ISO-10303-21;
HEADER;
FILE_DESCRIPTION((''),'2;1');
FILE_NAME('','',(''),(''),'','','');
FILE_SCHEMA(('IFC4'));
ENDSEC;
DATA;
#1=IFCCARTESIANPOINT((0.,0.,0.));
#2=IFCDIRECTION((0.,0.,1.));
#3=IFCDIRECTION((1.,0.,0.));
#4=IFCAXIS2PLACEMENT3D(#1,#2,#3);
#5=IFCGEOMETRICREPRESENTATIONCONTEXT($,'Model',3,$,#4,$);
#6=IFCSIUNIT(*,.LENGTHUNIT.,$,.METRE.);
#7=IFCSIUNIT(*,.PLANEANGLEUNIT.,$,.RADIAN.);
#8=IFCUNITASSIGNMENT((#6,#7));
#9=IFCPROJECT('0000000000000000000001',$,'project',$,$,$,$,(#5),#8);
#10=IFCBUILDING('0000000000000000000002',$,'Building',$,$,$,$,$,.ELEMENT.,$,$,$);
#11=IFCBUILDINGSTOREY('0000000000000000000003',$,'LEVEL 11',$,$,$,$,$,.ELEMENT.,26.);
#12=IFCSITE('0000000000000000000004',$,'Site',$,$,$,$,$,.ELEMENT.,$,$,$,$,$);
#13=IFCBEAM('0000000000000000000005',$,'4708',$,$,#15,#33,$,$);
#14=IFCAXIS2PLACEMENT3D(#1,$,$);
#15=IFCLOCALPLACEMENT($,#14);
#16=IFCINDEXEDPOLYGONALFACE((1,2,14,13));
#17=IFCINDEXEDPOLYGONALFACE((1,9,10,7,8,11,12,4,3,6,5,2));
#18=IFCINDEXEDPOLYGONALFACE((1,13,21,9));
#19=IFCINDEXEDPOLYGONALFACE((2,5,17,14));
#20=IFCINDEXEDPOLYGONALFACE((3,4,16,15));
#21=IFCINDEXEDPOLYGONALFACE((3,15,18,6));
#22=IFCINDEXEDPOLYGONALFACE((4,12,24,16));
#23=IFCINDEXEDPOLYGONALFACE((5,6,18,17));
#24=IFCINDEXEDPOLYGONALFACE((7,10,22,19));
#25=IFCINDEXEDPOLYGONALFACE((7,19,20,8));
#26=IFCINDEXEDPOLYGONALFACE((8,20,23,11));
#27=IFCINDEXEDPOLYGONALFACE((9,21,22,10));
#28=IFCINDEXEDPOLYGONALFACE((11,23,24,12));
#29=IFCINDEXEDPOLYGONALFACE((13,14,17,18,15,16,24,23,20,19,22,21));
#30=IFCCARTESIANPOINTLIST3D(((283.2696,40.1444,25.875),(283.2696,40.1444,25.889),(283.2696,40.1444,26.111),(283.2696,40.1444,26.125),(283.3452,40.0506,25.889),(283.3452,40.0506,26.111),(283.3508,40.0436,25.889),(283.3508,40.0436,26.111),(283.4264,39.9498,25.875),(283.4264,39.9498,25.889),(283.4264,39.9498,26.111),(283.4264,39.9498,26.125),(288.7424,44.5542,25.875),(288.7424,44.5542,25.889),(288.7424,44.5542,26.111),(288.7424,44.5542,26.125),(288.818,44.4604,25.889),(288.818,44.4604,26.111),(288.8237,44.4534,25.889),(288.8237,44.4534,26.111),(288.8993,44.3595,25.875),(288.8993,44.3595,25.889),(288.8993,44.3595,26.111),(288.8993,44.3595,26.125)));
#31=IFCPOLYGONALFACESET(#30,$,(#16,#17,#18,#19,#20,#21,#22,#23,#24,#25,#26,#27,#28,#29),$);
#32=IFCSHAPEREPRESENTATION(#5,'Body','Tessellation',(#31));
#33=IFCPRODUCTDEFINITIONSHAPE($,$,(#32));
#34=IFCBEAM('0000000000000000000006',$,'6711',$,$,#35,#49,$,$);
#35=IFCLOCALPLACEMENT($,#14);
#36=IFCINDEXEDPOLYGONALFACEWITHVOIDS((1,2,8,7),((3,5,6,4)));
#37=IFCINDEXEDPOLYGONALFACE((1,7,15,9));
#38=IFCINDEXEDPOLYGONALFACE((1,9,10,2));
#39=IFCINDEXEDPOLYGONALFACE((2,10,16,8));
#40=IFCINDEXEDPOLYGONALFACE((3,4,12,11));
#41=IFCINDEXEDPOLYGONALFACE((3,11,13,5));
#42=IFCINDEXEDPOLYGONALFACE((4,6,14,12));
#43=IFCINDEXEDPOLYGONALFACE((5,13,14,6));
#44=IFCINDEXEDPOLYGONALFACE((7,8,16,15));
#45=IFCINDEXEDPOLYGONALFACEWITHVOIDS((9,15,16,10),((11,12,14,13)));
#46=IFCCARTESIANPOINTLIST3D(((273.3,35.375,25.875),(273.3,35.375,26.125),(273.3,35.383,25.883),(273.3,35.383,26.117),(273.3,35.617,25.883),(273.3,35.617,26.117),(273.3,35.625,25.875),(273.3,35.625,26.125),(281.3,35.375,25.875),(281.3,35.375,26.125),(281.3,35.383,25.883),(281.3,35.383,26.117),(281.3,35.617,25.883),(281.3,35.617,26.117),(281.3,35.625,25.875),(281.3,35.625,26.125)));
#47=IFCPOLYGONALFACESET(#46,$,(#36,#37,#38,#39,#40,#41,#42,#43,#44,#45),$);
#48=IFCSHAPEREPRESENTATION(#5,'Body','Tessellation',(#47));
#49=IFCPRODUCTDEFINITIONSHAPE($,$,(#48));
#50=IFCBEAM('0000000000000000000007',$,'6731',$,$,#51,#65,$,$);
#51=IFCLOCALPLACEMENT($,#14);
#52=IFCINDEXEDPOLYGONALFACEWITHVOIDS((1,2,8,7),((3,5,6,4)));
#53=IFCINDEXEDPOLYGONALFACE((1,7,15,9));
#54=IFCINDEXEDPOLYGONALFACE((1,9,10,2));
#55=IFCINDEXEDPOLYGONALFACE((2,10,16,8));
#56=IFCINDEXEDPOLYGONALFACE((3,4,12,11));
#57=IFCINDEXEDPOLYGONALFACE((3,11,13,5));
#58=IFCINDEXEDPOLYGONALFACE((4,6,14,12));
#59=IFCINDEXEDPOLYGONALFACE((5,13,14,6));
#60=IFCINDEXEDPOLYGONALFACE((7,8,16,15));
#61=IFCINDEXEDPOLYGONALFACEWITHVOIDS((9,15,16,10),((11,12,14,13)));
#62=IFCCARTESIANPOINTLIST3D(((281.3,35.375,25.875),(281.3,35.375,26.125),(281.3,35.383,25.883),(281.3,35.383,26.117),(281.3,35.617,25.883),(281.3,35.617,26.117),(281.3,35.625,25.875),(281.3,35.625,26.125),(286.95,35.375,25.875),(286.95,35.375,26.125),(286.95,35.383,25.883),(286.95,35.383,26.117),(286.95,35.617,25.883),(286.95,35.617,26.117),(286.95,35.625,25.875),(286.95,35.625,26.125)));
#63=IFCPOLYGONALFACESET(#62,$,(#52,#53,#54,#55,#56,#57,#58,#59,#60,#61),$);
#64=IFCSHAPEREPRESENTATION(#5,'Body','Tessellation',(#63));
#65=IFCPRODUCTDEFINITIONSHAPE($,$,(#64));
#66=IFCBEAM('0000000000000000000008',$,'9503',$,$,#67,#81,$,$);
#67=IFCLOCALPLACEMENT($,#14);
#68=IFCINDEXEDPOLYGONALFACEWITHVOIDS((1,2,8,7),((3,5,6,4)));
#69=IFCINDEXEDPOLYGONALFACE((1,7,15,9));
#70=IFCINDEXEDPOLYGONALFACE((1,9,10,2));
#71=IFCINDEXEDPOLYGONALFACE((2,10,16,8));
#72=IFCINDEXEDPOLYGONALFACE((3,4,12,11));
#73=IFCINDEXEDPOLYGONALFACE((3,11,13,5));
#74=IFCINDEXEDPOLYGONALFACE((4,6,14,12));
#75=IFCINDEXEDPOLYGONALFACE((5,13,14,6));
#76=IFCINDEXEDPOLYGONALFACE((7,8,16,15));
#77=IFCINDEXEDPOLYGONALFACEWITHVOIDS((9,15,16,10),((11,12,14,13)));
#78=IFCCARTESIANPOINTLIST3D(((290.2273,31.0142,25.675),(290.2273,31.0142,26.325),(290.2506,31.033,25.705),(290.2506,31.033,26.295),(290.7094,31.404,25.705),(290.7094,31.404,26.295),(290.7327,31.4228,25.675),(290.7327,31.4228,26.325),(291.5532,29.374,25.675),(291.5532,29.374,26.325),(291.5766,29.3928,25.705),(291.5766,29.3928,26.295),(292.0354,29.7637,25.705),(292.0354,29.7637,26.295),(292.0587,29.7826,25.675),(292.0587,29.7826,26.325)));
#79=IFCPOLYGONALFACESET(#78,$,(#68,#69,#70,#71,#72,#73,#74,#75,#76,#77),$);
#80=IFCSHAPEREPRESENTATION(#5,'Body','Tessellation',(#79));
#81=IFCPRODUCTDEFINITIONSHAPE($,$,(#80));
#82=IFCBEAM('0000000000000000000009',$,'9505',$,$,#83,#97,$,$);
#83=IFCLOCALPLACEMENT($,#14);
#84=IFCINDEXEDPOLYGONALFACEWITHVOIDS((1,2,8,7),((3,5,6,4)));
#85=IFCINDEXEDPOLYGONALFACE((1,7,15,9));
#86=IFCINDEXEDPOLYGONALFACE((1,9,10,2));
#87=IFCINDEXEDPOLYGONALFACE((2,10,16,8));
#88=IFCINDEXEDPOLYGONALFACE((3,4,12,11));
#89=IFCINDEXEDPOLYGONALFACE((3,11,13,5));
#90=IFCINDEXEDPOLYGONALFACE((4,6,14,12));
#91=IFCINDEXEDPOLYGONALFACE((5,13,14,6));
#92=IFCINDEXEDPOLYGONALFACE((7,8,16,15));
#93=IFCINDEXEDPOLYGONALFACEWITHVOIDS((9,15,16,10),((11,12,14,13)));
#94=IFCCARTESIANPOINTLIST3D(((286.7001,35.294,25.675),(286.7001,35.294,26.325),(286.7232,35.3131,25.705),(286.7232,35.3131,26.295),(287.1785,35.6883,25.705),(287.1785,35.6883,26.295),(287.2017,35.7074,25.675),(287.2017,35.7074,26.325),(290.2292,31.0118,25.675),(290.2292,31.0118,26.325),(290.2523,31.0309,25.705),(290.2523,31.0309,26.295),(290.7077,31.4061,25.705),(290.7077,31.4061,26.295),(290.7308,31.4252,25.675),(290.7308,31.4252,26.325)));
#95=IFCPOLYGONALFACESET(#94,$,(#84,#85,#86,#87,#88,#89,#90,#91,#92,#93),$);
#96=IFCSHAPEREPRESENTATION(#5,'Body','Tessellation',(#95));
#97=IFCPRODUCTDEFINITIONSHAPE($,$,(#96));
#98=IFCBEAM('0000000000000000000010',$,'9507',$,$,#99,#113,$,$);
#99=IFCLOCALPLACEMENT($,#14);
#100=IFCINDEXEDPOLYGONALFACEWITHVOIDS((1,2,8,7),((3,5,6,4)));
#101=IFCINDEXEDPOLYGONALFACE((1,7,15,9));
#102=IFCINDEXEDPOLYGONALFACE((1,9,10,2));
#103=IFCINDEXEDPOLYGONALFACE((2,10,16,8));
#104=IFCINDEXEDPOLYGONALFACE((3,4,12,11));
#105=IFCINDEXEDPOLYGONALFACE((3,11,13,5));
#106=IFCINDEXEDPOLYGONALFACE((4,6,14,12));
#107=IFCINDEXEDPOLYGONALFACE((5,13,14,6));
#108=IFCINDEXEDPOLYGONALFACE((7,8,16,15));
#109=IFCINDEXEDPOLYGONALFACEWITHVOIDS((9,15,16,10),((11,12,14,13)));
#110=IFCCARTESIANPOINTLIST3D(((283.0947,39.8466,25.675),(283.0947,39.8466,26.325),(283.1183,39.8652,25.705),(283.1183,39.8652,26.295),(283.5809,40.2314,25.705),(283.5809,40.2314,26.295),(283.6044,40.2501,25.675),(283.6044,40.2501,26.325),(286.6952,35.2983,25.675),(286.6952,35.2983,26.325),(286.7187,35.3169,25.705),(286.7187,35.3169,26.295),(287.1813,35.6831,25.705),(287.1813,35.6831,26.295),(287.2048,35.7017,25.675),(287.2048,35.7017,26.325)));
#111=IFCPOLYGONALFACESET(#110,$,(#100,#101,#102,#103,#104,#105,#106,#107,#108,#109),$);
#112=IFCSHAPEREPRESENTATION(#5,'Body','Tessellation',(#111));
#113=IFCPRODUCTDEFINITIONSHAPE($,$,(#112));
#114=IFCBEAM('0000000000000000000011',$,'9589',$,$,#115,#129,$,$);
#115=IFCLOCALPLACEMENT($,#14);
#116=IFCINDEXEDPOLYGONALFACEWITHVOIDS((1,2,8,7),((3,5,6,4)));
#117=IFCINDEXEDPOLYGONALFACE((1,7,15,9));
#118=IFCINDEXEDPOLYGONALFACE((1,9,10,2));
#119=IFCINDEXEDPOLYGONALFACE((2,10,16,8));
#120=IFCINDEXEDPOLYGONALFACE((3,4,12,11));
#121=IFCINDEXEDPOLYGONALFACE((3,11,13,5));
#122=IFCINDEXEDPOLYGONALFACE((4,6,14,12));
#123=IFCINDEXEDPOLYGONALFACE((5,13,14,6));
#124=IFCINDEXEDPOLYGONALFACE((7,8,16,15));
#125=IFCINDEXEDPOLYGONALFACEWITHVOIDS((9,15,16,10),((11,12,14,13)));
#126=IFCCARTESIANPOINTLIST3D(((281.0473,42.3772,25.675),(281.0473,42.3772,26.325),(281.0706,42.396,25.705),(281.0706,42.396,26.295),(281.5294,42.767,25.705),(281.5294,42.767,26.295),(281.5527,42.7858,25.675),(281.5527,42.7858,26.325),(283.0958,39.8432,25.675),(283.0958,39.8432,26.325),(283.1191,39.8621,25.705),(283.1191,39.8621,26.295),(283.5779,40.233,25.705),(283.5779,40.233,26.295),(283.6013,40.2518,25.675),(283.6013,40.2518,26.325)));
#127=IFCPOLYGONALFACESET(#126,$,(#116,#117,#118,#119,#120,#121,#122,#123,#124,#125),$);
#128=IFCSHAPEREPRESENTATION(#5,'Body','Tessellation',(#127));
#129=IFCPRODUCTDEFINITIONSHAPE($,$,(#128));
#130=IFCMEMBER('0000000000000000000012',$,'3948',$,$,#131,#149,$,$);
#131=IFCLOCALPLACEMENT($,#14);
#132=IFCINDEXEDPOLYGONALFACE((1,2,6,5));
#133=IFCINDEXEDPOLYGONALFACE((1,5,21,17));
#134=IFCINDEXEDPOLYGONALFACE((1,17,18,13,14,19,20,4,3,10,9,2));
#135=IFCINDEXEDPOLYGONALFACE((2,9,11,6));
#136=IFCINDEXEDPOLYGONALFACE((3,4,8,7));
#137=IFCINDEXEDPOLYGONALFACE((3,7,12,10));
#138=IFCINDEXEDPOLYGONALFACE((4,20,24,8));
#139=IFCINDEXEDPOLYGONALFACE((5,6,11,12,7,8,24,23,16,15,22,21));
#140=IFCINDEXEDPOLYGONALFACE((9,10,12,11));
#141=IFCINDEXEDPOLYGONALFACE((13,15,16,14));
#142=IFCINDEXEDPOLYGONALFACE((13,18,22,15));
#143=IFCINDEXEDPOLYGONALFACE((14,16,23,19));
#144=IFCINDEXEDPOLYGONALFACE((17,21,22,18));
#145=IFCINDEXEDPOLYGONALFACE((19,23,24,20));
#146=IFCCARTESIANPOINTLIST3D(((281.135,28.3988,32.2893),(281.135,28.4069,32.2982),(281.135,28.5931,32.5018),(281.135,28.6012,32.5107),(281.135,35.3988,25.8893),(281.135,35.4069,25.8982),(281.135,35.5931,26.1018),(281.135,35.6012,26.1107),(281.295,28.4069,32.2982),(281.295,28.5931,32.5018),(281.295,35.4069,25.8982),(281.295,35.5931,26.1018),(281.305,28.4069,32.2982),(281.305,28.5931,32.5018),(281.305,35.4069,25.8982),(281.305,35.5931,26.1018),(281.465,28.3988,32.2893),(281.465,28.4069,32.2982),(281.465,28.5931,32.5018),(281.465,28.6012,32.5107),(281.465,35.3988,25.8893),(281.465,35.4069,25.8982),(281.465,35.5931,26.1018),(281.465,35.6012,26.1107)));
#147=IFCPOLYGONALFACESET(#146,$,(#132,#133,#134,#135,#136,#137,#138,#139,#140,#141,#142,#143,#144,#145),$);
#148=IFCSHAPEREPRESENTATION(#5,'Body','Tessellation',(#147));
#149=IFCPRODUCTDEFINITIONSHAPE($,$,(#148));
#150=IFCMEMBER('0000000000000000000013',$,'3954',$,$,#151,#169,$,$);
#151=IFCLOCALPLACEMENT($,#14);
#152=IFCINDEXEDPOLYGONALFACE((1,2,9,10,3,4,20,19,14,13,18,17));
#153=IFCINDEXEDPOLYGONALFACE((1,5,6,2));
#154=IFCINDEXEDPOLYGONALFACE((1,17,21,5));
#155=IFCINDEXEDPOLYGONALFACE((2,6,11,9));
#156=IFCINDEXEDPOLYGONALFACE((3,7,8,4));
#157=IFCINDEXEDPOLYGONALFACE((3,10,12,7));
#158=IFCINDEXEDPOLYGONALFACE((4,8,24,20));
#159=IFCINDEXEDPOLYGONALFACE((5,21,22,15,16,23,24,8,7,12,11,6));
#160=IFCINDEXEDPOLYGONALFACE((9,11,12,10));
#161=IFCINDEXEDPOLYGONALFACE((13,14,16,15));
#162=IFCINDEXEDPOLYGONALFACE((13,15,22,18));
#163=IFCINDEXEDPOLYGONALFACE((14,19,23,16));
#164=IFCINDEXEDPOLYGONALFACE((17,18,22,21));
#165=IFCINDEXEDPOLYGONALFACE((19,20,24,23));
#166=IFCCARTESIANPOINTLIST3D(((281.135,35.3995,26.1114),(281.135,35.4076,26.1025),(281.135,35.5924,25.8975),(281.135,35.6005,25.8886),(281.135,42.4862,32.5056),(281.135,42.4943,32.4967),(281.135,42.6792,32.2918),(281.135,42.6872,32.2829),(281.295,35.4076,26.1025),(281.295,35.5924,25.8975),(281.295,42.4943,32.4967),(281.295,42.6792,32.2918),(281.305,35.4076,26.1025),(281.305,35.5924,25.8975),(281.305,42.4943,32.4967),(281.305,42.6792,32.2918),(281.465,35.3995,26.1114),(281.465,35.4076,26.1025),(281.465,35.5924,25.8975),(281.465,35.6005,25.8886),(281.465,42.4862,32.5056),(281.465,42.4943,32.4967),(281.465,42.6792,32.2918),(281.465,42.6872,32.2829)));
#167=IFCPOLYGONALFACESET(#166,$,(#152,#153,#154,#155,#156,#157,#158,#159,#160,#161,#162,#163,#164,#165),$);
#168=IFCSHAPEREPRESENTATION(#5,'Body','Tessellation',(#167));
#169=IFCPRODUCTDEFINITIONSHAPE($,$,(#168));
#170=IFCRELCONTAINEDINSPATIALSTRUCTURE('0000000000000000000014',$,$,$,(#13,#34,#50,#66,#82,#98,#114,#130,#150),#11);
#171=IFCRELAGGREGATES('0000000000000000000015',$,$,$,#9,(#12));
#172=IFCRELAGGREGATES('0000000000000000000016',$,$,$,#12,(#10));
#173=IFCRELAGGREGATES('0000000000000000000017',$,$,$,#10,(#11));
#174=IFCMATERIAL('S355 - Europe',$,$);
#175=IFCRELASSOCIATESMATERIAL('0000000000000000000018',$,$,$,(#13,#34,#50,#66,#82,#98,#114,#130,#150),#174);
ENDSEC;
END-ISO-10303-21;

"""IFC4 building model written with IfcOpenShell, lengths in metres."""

from ifc_helpers import new_model, si_unit, frame, origin_with_axes, origin_2d_with_axis, place, context, project, spatial, hollow_rectangle, i_section, extrude, material, material_profile, profile_set, profile_usage, element, save


model = new_model("IFC4")

# Units and contexts
model_context = context("Model", 3, world=origin_with_axes())
ifc_project = project(units=[si_unit("LENGTHUNIT", "METRE"), si_unit("PLANEANGLEUNIT", "RADIAN")], contexts=[model_context])

# Site, building, storey
site = spatial("IfcSite", under=ifc_project, Name="Site", CompositionType="ELEMENT")
building = spatial("IfcBuilding", under=site, Name="Building", CompositionType="ELEMENT")
storey = spatial("IfcBuildingStorey", under=building, Name="LEVEL 11", CompositionType="ELEMENT", Elevation=26.0)

# Shared definitions
ifc_material = material(Name="S355 - Europe")

# Beams
ifc_material_profile_1 = material_profile(ifc_material, i_section(OverallWidth=0.25, OverallDepth=0.25, WebThickness=0.009, FlangeThickness=0.014, at=origin_2d_with_axis()))
ifc_profile_set_1 = profile_set([ifc_material_profile_1])
ifc_profile_usage_1 = profile_usage(ifc_profile_set_1, cardinal=10)
beam_1_placement = place(None, frame((283.348, 40.0471, 26.0), z_axis=(0.77868, 0.627421, 0.0), x_axis=(-0.627421, 0.77868, 0.0)))
element("IfcBeam", 1, at=beam_1_placement, inside=storey, material=ifc_profile_usage_1, Name="4708", context=model_context, shape_type="SweptSolid", body=[
    extrude(i_section(OverallWidth=0.25, OverallDepth=0.25, WebThickness=0.009, FlangeThickness=0.014, at=origin_2d_with_axis()), origin_with_axes(), (0.0, 0.0, 1.0), 7.0284),
])
ifc_material_profile_2 = material_profile(ifc_material, hollow_rectangle(XDim=0.25, YDim=0.25, WallThickness=0.008, at=origin_2d_with_axis()))
ifc_profile_set_2 = profile_set([ifc_material_profile_2])
ifc_profile_usage_2 = profile_usage(ifc_profile_set_2, cardinal=10)
beam_2_placement = place(None, frame((281.3, 35.5, 26.0), z_axis=(-1.0, 0.0, 0.0), x_axis=(0.0, -1.0, 0.0)))
element("IfcBeam", 2, at=beam_2_placement, inside=storey, material=ifc_profile_usage_2, Name="6711", context=model_context, shape_type="SweptSolid", body=[
    extrude(hollow_rectangle(XDim=0.25, YDim=0.25, WallThickness=0.008, at=origin_2d_with_axis()), origin_with_axes(), (0.0, 0.0, 1.0), 8.0),
])
ifc_material_profile_3 = material_profile(ifc_material, hollow_rectangle(XDim=0.25, YDim=0.25, WallThickness=0.008, at=origin_2d_with_axis()))
ifc_profile_set_3 = profile_set([ifc_material_profile_3])
ifc_profile_usage_3 = profile_usage(ifc_profile_set_3, cardinal=10)
beam_3_placement = place(None, frame((286.95, 35.5, 26.0), z_axis=(-1.0, 0.0, 0.0), x_axis=(0.0, -1.0, 0.0)))
element("IfcBeam", 3, at=beam_3_placement, inside=storey, material=ifc_profile_usage_3, Name="6731", context=model_context, shape_type="SweptSolid", body=[
    extrude(hollow_rectangle(XDim=0.25, YDim=0.25, WallThickness=0.008, at=origin_2d_with_axis()), origin_with_axes(), (0.0, 0.0, 1.0), 5.65),
])
ifc_material_profile_4 = material_profile(ifc_material, hollow_rectangle(XDim=0.65, YDim=0.65, WallThickness=0.03, at=origin_2d_with_axis()))
ifc_profile_set_4 = profile_set([ifc_material_profile_4])
ifc_profile_usage_4 = profile_usage(ifc_profile_set_4, cardinal=10)
beam_4_placement = place(None, frame((290.48, 31.2185, 26.0), z_axis=(0.628678, -0.777665, 0.0), x_axis=(0.777305, 0.629124, 0.0)))
element("IfcBeam", 4, at=beam_4_placement, inside=storey, material=ifc_profile_usage_4, Name="9503", context=model_context, shape_type="SweptSolid", body=[
    extrude(hollow_rectangle(XDim=0.65, YDim=0.65, WallThickness=0.03, at=origin_2d_with_axis()), origin_with_axes(), (0.0, 0.0, 1.0), 2.1092),
])
ifc_material_profile_5 = material_profile(ifc_material, hollow_rectangle(XDim=0.65, YDim=0.65, WallThickness=0.03, at=origin_2d_with_axis()))
ifc_profile_set_5 = profile_set([ifc_material_profile_5])
ifc_profile_usage_5 = profile_usage(ifc_profile_set_5, cardinal=10)
beam_5_placement = place(None, frame((290.48, 31.2185, 26.0), z_axis=(-0.635983, 0.771703, 0.0), x_axis=(-0.771703, -0.635983, 0.0)))
element("IfcBeam", 5, at=beam_5_placement, inside=storey, material=ifc_profile_usage_5, Name="9505", context=model_context, shape_type="SweptSolid", body=[
    extrude(hollow_rectangle(XDim=0.65, YDim=0.65, WallThickness=0.03, at=origin_2d_with_axis()), origin_with_axes(), (0.0, 0.0, 1.0), 5.5491),
])
ifc_material_profile_6 = material_profile(ifc_material, hollow_rectangle(XDim=0.65, YDim=0.65, WallThickness=0.03, at=origin_2d_with_axis()))
ifc_profile_set_6 = profile_set([ifc_material_profile_6])
ifc_profile_usage_6 = profile_usage(ifc_profile_set_6, cardinal=10)
beam_6_placement = place(None, frame((286.95, 35.5, 26.0), z_axis=(-0.620667, 0.784074, 0.0), x_axis=(-0.783587, -0.621282, 0.0)))
element("IfcBeam", 6, at=beam_6_placement, inside=storey, material=ifc_profile_usage_6, Name="9507", context=model_context, shape_type="SweptSolid", body=[
    extrude(hollow_rectangle(XDim=0.65, YDim=0.65, WallThickness=0.03, at=origin_2d_with_axis()), origin_with_axes(), (0.0, 0.0, 1.0), 5.8009),
])
ifc_material_profile_7 = material_profile(ifc_material, hollow_rectangle(XDim=0.65, YDim=0.65, WallThickness=0.03, at=origin_2d_with_axis()))
ifc_profile_set_7 = profile_set([ifc_material_profile_7])
ifc_profile_usage_7 = profile_usage(ifc_profile_set_7, cardinal=10)
beam_7_placement = place(None, frame((281.3, 42.5815, 26.0), z_axis=(0.628678, -0.777665, 0.0), x_axis=(0.777305, 0.629124, 0.0)))
element("IfcBeam", 7, at=beam_7_placement, inside=storey, material=ifc_profile_usage_7, Name="9589", context=model_context, shape_type="SweptSolid", body=[
    extrude(hollow_rectangle(XDim=0.65, YDim=0.65, WallThickness=0.03, at=origin_2d_with_axis()), origin_with_axes(), (0.0, 0.0, 1.0), 3.2584),
])

# Members
ifc_material_profile_8 = material_profile(ifc_material, i_section(OverallWidth=0.33, OverallDepth=0.3, WebThickness=0.01, FlangeThickness=0.012, at=origin_2d_with_axis()))
ifc_profile_set_8 = profile_set([ifc_material_profile_8])
ifc_profile_usage_8 = profile_usage(ifc_profile_set_8, cardinal=10)
member_1_placement = place(None, frame((281.3, 28.5, 32.4), z_axis=(0.0, 0.738029, -0.674769), x_axis=(-1.0, 0.0, 0.0)))
element("IfcMember", 8, at=member_1_placement, inside=storey, material=ifc_profile_usage_8, Name="3948", context=model_context, shape_type="SweptSolid", body=[
    extrude(i_section(OverallWidth=0.33, OverallDepth=0.3, WebThickness=0.01, FlangeThickness=0.012, at=origin_2d_with_axis()), origin_with_axes(), (0.0, 0.0, 1.0), 9.4847),
])
ifc_material_profile_9 = material_profile(ifc_material, i_section(OverallWidth=0.33, OverallDepth=0.3, WebThickness=0.01, FlangeThickness=0.012, at=origin_2d_with_axis()))
ifc_profile_set_9 = profile_set([ifc_material_profile_9])
ifc_profile_usage_9 = profile_usage(ifc_profile_set_9, cardinal=10)
member_2_placement = place(None, frame((281.3, 35.5, 26.0), z_axis=(0.0, 0.74245, 0.669902), x_axis=(-1.0, 0.0, 0.0)))
element("IfcMember", 9, at=member_2_placement, inside=storey, material=ifc_profile_usage_9, Name="3954", context=model_context, shape_type="SweptSolid", body=[
    extrude(i_section(OverallWidth=0.33, OverallDepth=0.3, WebThickness=0.01, FlangeThickness=0.012, at=origin_2d_with_axis()), origin_with_axes(), (0.0, 0.0, 1.0), 9.545),
])

save(model, "model.ifc")
